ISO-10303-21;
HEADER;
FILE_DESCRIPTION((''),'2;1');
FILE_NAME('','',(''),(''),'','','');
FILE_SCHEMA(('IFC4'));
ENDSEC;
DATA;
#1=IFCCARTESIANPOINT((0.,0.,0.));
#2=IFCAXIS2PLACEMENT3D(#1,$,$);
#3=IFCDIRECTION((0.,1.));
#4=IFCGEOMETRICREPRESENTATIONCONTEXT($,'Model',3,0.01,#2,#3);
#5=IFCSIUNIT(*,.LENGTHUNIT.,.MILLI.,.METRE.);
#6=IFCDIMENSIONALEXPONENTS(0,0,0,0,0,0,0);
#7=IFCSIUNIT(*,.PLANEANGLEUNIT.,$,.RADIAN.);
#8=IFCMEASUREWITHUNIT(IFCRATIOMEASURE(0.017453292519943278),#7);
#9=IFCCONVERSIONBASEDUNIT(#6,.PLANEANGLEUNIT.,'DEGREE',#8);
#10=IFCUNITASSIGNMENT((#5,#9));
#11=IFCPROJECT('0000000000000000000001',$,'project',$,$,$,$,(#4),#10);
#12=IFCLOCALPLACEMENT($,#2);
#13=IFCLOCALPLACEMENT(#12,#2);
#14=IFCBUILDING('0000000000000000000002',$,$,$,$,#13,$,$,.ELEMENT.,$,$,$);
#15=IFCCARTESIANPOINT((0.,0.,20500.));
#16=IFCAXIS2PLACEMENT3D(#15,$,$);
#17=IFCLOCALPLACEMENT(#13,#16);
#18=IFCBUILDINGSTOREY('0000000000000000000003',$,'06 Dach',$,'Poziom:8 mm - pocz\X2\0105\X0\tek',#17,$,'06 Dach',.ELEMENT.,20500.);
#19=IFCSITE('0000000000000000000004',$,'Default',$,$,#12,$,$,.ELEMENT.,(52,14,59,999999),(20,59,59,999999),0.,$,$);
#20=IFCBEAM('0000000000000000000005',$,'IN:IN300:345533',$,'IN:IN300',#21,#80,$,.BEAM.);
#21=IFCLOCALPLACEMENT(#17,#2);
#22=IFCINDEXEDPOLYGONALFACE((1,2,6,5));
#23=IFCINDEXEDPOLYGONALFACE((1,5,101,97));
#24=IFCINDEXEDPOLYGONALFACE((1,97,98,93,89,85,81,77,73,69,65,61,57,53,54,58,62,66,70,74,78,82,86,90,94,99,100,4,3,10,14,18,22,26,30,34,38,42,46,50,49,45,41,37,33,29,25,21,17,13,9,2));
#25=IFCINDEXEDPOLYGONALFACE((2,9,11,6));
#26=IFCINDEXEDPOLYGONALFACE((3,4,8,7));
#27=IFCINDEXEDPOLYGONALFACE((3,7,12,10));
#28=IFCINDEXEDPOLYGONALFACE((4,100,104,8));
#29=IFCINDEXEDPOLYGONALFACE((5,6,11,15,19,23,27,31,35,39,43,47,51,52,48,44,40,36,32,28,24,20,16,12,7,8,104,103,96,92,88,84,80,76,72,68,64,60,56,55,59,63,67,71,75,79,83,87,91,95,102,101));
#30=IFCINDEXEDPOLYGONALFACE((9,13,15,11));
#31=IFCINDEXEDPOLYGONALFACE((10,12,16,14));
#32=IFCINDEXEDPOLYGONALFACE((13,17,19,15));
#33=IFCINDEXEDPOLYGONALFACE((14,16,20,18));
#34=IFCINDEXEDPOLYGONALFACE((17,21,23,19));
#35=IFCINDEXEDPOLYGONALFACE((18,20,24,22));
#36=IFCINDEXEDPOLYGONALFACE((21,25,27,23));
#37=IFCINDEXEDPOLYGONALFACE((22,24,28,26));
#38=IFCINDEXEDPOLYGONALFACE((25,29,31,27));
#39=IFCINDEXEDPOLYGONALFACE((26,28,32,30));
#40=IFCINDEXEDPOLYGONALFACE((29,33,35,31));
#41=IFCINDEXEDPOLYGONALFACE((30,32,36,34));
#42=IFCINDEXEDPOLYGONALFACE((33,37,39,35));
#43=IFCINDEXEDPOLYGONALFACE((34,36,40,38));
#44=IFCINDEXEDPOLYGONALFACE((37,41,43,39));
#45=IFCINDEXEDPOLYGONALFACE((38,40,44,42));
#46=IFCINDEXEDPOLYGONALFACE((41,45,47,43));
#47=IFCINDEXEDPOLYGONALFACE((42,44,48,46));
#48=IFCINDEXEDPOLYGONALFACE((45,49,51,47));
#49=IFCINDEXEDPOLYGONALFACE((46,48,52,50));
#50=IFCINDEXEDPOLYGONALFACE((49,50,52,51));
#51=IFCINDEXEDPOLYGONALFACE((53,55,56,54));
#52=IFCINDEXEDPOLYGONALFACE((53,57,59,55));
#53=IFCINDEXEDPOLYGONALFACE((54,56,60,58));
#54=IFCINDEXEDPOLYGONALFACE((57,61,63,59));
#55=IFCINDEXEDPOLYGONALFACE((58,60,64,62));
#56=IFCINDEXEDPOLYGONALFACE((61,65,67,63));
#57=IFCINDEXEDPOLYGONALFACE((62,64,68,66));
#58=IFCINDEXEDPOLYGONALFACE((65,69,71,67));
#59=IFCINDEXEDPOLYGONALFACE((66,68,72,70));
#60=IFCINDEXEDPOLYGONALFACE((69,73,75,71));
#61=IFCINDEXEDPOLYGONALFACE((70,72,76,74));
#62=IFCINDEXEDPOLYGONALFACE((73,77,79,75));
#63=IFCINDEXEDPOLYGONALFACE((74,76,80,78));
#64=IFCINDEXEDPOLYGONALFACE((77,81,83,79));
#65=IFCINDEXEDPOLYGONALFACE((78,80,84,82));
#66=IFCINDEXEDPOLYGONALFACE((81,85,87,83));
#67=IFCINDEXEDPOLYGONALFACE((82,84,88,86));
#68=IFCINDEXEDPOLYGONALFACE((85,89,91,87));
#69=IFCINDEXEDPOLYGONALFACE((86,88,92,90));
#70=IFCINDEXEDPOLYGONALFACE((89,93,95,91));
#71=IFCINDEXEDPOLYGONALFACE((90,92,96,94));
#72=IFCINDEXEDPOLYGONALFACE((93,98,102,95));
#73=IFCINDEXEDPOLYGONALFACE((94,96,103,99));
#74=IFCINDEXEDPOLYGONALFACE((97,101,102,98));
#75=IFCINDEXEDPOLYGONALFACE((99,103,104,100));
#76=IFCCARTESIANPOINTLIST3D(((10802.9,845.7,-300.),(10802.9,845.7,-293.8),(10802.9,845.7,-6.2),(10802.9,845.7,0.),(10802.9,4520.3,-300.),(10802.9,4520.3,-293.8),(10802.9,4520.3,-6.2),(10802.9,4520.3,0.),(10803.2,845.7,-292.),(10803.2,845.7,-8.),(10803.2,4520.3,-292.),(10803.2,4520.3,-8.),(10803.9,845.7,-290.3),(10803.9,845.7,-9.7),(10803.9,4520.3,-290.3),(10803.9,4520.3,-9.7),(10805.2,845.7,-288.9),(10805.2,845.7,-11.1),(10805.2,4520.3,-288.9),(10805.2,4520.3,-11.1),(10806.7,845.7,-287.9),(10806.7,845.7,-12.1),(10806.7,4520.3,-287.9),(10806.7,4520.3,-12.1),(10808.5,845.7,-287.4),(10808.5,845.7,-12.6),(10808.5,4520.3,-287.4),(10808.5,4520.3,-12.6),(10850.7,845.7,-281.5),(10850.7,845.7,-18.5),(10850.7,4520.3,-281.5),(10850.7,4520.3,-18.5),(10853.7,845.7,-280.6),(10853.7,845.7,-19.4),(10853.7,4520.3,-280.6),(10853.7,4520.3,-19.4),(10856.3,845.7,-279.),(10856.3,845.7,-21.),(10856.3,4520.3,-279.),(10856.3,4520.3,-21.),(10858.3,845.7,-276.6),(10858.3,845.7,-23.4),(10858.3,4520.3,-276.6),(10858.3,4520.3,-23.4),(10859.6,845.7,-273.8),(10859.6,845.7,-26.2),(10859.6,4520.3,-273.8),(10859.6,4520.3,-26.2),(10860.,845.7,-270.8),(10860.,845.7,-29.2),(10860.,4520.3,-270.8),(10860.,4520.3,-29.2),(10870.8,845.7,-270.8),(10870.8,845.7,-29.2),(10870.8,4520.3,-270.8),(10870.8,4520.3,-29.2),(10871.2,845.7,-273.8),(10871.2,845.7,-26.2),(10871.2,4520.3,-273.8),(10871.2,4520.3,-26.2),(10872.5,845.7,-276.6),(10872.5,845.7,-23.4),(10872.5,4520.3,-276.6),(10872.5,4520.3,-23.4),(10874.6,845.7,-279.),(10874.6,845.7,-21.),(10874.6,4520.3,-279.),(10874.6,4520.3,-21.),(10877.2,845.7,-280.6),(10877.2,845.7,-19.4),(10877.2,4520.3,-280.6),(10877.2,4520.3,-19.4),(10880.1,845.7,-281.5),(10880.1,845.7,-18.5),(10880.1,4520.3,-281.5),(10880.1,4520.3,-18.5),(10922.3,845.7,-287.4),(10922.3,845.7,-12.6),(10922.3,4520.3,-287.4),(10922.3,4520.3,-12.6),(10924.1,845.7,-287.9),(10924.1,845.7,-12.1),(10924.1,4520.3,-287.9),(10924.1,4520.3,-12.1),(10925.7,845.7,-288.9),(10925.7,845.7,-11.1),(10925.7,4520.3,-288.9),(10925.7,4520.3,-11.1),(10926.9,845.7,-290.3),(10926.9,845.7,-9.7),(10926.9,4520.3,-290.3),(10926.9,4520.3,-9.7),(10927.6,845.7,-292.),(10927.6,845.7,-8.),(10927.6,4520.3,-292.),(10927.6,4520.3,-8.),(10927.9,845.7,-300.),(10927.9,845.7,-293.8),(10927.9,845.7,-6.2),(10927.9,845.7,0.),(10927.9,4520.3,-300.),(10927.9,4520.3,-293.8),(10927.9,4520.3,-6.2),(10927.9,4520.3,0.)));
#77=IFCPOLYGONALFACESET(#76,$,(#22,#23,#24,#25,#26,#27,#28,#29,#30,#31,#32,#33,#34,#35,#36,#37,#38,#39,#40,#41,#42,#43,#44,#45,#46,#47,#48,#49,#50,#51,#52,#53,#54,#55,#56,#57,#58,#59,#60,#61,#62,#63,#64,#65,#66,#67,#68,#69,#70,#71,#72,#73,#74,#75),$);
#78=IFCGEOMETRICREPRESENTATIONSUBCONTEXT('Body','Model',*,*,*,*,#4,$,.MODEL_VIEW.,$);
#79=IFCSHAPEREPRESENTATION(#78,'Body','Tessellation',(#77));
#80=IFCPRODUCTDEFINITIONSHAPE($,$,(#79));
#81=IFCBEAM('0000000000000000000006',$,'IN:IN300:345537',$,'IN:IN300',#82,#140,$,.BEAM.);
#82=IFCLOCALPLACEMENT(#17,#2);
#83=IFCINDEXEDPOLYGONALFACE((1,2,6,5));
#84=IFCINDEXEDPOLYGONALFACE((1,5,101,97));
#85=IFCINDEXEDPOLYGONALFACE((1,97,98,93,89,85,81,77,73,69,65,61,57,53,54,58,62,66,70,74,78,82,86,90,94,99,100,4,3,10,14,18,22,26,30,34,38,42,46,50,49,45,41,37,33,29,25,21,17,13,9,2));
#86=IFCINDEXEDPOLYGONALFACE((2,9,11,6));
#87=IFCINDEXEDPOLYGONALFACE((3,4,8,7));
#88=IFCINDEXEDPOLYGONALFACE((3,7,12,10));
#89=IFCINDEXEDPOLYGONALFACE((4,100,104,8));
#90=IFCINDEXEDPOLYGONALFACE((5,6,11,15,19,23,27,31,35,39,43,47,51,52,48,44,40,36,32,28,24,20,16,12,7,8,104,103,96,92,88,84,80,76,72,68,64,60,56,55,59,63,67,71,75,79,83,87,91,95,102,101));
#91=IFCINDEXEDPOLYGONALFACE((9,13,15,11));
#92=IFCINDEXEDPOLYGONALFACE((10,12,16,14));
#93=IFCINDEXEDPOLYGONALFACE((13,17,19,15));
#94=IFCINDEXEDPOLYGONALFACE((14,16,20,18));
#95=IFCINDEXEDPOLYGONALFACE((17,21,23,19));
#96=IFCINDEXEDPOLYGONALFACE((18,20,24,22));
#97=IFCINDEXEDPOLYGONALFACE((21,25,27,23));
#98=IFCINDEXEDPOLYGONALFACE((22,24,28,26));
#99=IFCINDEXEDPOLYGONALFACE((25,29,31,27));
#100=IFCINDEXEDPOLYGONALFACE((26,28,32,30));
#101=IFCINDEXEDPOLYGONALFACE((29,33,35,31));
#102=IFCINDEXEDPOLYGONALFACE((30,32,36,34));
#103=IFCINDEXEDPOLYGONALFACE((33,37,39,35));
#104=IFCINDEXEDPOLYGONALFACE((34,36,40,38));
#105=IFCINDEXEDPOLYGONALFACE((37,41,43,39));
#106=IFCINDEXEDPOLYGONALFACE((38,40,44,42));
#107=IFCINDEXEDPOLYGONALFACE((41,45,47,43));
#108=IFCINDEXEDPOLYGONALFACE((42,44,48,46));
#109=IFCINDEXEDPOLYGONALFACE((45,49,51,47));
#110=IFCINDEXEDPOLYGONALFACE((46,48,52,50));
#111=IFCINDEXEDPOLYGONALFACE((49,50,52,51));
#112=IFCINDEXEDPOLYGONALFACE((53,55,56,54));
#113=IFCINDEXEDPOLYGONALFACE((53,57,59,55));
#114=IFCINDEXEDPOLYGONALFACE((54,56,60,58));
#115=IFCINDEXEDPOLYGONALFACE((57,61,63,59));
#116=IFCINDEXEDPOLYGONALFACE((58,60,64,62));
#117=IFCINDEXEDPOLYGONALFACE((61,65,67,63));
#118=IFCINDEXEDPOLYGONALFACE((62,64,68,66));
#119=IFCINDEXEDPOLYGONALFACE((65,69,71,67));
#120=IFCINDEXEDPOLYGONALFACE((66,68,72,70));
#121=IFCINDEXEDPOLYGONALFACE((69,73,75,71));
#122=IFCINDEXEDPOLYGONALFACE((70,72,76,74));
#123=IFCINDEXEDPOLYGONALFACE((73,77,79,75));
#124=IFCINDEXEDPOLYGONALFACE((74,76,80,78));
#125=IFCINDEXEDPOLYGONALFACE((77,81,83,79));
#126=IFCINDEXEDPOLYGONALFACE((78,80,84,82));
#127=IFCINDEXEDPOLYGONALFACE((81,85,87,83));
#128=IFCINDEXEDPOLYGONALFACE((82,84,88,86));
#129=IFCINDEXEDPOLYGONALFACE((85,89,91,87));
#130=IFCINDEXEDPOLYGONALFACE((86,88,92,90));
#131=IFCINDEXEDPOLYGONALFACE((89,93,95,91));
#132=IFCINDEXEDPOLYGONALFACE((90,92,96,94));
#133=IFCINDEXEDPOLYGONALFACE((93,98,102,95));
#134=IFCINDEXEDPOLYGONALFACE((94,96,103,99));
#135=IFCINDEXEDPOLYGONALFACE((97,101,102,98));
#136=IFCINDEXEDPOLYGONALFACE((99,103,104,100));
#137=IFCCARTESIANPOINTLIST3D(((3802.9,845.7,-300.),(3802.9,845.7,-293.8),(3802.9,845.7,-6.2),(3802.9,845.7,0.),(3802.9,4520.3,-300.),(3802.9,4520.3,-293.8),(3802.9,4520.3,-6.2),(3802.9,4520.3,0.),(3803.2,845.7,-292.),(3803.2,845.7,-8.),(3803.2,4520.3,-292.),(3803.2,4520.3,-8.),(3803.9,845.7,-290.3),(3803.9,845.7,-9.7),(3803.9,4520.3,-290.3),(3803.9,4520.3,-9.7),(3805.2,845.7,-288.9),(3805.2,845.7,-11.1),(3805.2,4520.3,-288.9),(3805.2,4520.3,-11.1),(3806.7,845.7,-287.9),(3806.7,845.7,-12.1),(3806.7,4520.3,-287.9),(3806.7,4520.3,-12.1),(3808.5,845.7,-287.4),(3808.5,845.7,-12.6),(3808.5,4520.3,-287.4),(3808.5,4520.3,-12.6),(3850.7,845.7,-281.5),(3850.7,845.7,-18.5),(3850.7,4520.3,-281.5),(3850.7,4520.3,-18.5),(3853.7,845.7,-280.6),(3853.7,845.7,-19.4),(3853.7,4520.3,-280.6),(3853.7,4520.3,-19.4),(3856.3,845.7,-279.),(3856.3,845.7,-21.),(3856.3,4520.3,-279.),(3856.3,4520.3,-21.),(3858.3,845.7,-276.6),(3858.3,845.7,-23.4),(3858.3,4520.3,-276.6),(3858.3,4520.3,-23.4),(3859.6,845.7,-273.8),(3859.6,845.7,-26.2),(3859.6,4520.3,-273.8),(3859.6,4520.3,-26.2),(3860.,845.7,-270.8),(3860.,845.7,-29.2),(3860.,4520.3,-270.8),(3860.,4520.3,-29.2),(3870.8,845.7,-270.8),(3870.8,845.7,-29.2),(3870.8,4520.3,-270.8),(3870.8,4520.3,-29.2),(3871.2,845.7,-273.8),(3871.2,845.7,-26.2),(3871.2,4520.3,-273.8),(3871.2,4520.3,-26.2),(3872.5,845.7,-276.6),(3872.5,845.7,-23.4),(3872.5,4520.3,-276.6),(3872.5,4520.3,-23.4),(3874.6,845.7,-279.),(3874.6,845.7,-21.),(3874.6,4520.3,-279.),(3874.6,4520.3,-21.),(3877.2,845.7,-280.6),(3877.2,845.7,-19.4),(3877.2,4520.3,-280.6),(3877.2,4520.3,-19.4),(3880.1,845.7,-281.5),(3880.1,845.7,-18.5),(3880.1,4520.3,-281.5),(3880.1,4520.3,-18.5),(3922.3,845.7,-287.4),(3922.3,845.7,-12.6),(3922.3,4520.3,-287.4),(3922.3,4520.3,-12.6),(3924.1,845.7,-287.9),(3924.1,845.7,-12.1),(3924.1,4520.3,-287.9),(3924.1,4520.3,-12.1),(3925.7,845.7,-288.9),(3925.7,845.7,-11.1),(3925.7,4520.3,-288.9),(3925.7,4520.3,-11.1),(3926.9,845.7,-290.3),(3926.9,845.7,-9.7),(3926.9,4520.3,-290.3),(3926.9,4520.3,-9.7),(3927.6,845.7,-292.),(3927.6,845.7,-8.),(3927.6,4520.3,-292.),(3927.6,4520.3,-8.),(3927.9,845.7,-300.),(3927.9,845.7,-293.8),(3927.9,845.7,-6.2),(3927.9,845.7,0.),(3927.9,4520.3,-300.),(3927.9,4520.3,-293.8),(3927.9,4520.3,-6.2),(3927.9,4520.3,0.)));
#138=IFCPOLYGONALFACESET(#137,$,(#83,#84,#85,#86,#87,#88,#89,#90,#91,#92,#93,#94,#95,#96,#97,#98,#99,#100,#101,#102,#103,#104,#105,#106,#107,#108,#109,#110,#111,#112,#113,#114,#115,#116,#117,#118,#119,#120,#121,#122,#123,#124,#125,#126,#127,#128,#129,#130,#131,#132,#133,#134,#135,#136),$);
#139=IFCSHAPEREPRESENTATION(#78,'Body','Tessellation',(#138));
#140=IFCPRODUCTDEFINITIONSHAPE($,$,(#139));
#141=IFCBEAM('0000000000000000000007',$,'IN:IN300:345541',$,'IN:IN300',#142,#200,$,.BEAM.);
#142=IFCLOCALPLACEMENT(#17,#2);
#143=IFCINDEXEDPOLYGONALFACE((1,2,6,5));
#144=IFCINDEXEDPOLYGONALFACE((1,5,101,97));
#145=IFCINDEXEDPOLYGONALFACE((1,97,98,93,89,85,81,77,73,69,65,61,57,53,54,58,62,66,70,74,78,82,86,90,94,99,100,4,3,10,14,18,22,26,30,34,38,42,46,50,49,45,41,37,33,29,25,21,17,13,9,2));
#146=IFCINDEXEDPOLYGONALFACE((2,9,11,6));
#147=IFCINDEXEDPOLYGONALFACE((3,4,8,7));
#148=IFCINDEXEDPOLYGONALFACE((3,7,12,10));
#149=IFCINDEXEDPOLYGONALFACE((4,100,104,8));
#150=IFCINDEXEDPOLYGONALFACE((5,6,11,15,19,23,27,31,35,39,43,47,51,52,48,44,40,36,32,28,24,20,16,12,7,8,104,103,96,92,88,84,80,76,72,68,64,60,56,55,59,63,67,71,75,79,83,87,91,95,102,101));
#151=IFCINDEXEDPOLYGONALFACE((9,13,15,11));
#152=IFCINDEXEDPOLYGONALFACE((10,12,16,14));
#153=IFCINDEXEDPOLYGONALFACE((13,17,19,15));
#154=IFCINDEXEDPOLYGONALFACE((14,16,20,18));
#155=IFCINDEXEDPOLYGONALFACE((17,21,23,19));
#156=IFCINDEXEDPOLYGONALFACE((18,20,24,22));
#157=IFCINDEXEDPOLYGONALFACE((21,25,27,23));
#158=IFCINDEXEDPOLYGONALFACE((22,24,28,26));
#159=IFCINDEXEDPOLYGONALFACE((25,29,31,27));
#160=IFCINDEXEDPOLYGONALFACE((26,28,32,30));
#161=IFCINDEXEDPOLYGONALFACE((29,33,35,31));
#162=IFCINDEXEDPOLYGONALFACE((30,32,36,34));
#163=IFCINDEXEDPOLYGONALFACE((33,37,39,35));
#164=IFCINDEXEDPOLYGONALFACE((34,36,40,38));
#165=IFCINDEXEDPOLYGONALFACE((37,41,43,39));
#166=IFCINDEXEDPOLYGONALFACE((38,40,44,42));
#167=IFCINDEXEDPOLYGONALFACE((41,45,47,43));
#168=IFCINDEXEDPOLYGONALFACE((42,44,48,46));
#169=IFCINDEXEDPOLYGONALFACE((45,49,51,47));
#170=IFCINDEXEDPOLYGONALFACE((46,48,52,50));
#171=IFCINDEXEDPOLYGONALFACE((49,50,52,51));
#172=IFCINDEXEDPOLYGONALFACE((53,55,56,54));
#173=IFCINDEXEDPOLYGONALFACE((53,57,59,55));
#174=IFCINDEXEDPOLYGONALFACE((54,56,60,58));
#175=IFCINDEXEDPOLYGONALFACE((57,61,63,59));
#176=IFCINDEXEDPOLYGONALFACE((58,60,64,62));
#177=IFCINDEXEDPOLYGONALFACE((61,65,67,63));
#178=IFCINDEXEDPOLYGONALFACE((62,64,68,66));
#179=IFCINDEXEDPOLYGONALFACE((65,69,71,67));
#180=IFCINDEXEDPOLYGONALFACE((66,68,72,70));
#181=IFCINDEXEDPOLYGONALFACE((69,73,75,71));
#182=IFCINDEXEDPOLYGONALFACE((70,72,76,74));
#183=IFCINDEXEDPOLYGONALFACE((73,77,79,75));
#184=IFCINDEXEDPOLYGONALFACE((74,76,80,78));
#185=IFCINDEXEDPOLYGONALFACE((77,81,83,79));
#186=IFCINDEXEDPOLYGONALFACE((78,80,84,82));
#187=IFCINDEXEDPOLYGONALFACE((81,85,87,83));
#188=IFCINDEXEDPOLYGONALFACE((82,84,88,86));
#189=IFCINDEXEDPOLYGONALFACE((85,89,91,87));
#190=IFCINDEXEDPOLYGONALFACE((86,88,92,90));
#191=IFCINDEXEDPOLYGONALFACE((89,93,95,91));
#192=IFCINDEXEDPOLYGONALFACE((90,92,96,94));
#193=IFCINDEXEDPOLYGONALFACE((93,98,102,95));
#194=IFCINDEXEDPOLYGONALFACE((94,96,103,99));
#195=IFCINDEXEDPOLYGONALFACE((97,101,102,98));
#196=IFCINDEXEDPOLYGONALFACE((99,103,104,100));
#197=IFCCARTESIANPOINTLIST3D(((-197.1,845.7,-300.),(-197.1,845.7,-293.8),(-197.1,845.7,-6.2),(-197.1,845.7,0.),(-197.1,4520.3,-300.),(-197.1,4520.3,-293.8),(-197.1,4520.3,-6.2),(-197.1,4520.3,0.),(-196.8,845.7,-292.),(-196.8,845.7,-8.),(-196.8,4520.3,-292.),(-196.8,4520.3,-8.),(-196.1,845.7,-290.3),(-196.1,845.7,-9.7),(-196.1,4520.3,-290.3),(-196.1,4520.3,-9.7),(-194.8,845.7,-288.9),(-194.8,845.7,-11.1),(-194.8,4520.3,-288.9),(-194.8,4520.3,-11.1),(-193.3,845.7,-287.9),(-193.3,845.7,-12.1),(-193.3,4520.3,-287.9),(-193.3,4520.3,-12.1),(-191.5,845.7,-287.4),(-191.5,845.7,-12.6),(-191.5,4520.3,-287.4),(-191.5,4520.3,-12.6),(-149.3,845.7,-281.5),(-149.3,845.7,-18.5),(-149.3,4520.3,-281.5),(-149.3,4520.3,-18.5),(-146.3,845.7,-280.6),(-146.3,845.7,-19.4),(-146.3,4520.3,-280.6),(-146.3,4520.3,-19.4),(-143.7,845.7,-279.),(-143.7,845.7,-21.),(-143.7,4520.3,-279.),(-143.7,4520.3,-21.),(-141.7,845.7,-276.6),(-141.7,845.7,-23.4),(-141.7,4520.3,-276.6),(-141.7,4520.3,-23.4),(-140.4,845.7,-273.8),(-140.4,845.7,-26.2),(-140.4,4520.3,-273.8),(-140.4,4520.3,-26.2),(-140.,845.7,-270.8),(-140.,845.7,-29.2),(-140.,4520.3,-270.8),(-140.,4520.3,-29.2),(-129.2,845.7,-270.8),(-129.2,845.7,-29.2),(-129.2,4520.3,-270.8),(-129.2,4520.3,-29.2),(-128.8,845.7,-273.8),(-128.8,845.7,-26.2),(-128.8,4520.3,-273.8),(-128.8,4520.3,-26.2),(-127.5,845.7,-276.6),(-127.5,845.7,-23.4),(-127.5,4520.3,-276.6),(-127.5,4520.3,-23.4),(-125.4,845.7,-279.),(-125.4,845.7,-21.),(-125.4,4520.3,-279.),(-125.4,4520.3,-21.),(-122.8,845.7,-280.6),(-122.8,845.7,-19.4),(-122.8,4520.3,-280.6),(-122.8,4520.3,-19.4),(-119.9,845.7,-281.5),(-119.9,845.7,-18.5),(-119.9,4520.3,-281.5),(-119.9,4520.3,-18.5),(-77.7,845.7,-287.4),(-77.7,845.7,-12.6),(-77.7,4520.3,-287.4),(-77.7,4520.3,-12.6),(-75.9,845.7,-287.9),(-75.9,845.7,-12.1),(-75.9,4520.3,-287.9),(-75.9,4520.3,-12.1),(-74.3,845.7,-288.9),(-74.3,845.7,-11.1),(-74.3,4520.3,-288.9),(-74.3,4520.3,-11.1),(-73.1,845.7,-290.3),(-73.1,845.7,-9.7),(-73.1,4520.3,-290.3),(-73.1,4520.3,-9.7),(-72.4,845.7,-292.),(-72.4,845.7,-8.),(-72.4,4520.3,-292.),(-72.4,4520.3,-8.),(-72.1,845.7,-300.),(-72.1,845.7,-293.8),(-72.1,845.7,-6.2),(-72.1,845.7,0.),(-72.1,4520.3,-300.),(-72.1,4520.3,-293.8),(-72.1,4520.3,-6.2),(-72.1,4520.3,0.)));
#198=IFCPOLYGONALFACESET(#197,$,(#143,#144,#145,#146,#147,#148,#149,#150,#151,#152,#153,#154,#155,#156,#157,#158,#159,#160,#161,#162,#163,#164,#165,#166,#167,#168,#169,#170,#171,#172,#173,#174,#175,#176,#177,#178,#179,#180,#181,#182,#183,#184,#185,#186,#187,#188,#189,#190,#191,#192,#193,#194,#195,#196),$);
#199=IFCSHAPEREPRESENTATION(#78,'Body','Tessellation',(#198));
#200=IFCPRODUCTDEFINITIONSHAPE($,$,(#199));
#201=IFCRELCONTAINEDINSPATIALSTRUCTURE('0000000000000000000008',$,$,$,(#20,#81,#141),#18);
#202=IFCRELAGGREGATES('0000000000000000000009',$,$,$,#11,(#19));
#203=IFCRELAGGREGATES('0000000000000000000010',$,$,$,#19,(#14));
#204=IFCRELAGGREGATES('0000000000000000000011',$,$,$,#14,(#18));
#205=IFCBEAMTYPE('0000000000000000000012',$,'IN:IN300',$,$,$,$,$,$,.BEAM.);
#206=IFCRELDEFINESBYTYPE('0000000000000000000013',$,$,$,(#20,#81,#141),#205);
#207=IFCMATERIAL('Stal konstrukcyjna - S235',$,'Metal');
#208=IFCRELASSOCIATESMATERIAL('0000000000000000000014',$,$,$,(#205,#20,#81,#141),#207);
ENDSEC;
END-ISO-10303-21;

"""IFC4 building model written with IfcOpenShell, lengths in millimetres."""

from ifc_helpers import new_model, entity, si_unit, converted_unit, direction, frame, origin, place, context, subcontext, project, spatial, line, arc, indexed_curve, outline, extrude, source, transform, mapped, material, type_object, type_shapes, element, save


model = new_model("IFC4")

# Units and contexts
model_context = context("Model", 3, precision=0.01, world=origin(), true_north=direction((0.0, 1.0)))
body_context = subcontext(model_context, "Body", "Model", "MODEL_VIEW")
ifc_project = project(units=[si_unit("LENGTHUNIT", "METRE", prefix="MILLI"), converted_unit("PLANEANGLEUNIT", "DEGREE", entity("IfcRatioMeasure", 0.017453292519943278), si_unit("PLANEANGLEUNIT", "RADIAN"), dimensions=[0, 0, 0, 0, 0, 0, 0])], contexts=[model_context])

# Site, building, storey
site_placement = place(None, origin())
site = spatial("IfcSite", under=ifc_project, at=site_placement, Name="Default", CompositionType="ELEMENT", RefLatitude=(52, 14, 59, 999999), RefLongitude=(20, 59, 59, 999999), RefElevation=0.0)
building_placement = place(site_placement, origin())
building = spatial("IfcBuilding", under=site, at=building_placement, CompositionType="ELEMENT")
storey_placement = place(building_placement, frame((0.0, 0.0, 20500.0)))
storey = spatial("IfcBuildingStorey", under=building, at=storey_placement, Name="06 Dach", ObjectType="Poziom:8 mm - początek", LongName="06 Dach", CompositionType="ELEMENT", Elevation=20500.0)

# Beams
ifc_material = material(Name="Stal konstrukcyjna - S235", Category="Metal")
beam_type_1 = type_object("IfcBeamType", Name="IN:IN300", PredefinedType="BEAM", material=ifc_material)
shared_shape_1 = source(origin(), body_context, "Body", "SweptSolid", [
    extrude(outline(indexed_curve([(143.8, -62.5), (150.0, -62.5), (150.0, 62.5), (143.8, 62.5), (139.6, 60.9), (137.4, 56.9), (131.5, 14.7), (127.9, 8.1), (120.8, 5.4), (-120.8, 5.4), (-127.9, 8.1), (-131.5, 14.7), (-137.4, 56.9), (-139.6, 60.9), (-143.8, 62.5), (-150.0, 62.5), (-150.0, -62.5), (-143.8, -62.5), (-139.6, -60.9), (-137.4, -56.9), (-131.5, -14.7), (-127.9, -8.1), (-120.8, -5.4), (120.8, -5.4), (127.9, -8.1), (131.5, -14.7), (137.4, -56.9), (139.6, -60.9)], segments=[line(1, 2, 3, 4), arc(4, 5, 6), line(6, 7), arc(7, 8, 9), line(9, 10), arc(10, 11, 12), line(12, 13), arc(13, 14, 15), line(15, 16, 17, 18), arc(18, 19, 20), line(20, 21), arc(21, 22, 23), line(23, 24), arc(24, 25, 26), line(26, 27), arc(27, 28, 1)], self_intersect=False)), frame((-1837.3, 0.0, 0.0), z_axis=(1.0, 0.0, 0.0), x_axis=(0.0, 0.0, -1.0)), (0.0, 0.0, 1.0), 3674.6),
])
type_shapes(beam_type_1, [shared_shape_1])
for number, where, z_axis, x_axis, name in (
    (1, (10865.4, 2683.0, -150.0), (0.0, 0.0, 1.0), (0.0, -1.0, 0.0), "IN:IN300:345533"),
    (2, (3865.4, 2683.0, -150.0), (0.0, 0.0, 1.0), (0.0, -1.0, 0.0), "IN:IN300:345537"),
    (3, (-134.6, 2683.0, -150.0), (0.0, 0.0, 1.0), (0.0, -1.0, 0.0), "IN:IN300:345541"),
):
    element("IfcBeam", number, at=place(storey_placement, frame(where, z_axis=z_axis, x_axis=x_axis)), inside=storey, type_object=beam_type_1, material=ifc_material, Name=name, ObjectType="IN:IN300", PredefinedType="BEAM", context=body_context, shape_type="MappedRepresentation", body=[
        mapped(shared_shape_1, transform((0.0, 0.0, 0.0), scale=1.0)),
    ])

save(model, "model.ifc")
